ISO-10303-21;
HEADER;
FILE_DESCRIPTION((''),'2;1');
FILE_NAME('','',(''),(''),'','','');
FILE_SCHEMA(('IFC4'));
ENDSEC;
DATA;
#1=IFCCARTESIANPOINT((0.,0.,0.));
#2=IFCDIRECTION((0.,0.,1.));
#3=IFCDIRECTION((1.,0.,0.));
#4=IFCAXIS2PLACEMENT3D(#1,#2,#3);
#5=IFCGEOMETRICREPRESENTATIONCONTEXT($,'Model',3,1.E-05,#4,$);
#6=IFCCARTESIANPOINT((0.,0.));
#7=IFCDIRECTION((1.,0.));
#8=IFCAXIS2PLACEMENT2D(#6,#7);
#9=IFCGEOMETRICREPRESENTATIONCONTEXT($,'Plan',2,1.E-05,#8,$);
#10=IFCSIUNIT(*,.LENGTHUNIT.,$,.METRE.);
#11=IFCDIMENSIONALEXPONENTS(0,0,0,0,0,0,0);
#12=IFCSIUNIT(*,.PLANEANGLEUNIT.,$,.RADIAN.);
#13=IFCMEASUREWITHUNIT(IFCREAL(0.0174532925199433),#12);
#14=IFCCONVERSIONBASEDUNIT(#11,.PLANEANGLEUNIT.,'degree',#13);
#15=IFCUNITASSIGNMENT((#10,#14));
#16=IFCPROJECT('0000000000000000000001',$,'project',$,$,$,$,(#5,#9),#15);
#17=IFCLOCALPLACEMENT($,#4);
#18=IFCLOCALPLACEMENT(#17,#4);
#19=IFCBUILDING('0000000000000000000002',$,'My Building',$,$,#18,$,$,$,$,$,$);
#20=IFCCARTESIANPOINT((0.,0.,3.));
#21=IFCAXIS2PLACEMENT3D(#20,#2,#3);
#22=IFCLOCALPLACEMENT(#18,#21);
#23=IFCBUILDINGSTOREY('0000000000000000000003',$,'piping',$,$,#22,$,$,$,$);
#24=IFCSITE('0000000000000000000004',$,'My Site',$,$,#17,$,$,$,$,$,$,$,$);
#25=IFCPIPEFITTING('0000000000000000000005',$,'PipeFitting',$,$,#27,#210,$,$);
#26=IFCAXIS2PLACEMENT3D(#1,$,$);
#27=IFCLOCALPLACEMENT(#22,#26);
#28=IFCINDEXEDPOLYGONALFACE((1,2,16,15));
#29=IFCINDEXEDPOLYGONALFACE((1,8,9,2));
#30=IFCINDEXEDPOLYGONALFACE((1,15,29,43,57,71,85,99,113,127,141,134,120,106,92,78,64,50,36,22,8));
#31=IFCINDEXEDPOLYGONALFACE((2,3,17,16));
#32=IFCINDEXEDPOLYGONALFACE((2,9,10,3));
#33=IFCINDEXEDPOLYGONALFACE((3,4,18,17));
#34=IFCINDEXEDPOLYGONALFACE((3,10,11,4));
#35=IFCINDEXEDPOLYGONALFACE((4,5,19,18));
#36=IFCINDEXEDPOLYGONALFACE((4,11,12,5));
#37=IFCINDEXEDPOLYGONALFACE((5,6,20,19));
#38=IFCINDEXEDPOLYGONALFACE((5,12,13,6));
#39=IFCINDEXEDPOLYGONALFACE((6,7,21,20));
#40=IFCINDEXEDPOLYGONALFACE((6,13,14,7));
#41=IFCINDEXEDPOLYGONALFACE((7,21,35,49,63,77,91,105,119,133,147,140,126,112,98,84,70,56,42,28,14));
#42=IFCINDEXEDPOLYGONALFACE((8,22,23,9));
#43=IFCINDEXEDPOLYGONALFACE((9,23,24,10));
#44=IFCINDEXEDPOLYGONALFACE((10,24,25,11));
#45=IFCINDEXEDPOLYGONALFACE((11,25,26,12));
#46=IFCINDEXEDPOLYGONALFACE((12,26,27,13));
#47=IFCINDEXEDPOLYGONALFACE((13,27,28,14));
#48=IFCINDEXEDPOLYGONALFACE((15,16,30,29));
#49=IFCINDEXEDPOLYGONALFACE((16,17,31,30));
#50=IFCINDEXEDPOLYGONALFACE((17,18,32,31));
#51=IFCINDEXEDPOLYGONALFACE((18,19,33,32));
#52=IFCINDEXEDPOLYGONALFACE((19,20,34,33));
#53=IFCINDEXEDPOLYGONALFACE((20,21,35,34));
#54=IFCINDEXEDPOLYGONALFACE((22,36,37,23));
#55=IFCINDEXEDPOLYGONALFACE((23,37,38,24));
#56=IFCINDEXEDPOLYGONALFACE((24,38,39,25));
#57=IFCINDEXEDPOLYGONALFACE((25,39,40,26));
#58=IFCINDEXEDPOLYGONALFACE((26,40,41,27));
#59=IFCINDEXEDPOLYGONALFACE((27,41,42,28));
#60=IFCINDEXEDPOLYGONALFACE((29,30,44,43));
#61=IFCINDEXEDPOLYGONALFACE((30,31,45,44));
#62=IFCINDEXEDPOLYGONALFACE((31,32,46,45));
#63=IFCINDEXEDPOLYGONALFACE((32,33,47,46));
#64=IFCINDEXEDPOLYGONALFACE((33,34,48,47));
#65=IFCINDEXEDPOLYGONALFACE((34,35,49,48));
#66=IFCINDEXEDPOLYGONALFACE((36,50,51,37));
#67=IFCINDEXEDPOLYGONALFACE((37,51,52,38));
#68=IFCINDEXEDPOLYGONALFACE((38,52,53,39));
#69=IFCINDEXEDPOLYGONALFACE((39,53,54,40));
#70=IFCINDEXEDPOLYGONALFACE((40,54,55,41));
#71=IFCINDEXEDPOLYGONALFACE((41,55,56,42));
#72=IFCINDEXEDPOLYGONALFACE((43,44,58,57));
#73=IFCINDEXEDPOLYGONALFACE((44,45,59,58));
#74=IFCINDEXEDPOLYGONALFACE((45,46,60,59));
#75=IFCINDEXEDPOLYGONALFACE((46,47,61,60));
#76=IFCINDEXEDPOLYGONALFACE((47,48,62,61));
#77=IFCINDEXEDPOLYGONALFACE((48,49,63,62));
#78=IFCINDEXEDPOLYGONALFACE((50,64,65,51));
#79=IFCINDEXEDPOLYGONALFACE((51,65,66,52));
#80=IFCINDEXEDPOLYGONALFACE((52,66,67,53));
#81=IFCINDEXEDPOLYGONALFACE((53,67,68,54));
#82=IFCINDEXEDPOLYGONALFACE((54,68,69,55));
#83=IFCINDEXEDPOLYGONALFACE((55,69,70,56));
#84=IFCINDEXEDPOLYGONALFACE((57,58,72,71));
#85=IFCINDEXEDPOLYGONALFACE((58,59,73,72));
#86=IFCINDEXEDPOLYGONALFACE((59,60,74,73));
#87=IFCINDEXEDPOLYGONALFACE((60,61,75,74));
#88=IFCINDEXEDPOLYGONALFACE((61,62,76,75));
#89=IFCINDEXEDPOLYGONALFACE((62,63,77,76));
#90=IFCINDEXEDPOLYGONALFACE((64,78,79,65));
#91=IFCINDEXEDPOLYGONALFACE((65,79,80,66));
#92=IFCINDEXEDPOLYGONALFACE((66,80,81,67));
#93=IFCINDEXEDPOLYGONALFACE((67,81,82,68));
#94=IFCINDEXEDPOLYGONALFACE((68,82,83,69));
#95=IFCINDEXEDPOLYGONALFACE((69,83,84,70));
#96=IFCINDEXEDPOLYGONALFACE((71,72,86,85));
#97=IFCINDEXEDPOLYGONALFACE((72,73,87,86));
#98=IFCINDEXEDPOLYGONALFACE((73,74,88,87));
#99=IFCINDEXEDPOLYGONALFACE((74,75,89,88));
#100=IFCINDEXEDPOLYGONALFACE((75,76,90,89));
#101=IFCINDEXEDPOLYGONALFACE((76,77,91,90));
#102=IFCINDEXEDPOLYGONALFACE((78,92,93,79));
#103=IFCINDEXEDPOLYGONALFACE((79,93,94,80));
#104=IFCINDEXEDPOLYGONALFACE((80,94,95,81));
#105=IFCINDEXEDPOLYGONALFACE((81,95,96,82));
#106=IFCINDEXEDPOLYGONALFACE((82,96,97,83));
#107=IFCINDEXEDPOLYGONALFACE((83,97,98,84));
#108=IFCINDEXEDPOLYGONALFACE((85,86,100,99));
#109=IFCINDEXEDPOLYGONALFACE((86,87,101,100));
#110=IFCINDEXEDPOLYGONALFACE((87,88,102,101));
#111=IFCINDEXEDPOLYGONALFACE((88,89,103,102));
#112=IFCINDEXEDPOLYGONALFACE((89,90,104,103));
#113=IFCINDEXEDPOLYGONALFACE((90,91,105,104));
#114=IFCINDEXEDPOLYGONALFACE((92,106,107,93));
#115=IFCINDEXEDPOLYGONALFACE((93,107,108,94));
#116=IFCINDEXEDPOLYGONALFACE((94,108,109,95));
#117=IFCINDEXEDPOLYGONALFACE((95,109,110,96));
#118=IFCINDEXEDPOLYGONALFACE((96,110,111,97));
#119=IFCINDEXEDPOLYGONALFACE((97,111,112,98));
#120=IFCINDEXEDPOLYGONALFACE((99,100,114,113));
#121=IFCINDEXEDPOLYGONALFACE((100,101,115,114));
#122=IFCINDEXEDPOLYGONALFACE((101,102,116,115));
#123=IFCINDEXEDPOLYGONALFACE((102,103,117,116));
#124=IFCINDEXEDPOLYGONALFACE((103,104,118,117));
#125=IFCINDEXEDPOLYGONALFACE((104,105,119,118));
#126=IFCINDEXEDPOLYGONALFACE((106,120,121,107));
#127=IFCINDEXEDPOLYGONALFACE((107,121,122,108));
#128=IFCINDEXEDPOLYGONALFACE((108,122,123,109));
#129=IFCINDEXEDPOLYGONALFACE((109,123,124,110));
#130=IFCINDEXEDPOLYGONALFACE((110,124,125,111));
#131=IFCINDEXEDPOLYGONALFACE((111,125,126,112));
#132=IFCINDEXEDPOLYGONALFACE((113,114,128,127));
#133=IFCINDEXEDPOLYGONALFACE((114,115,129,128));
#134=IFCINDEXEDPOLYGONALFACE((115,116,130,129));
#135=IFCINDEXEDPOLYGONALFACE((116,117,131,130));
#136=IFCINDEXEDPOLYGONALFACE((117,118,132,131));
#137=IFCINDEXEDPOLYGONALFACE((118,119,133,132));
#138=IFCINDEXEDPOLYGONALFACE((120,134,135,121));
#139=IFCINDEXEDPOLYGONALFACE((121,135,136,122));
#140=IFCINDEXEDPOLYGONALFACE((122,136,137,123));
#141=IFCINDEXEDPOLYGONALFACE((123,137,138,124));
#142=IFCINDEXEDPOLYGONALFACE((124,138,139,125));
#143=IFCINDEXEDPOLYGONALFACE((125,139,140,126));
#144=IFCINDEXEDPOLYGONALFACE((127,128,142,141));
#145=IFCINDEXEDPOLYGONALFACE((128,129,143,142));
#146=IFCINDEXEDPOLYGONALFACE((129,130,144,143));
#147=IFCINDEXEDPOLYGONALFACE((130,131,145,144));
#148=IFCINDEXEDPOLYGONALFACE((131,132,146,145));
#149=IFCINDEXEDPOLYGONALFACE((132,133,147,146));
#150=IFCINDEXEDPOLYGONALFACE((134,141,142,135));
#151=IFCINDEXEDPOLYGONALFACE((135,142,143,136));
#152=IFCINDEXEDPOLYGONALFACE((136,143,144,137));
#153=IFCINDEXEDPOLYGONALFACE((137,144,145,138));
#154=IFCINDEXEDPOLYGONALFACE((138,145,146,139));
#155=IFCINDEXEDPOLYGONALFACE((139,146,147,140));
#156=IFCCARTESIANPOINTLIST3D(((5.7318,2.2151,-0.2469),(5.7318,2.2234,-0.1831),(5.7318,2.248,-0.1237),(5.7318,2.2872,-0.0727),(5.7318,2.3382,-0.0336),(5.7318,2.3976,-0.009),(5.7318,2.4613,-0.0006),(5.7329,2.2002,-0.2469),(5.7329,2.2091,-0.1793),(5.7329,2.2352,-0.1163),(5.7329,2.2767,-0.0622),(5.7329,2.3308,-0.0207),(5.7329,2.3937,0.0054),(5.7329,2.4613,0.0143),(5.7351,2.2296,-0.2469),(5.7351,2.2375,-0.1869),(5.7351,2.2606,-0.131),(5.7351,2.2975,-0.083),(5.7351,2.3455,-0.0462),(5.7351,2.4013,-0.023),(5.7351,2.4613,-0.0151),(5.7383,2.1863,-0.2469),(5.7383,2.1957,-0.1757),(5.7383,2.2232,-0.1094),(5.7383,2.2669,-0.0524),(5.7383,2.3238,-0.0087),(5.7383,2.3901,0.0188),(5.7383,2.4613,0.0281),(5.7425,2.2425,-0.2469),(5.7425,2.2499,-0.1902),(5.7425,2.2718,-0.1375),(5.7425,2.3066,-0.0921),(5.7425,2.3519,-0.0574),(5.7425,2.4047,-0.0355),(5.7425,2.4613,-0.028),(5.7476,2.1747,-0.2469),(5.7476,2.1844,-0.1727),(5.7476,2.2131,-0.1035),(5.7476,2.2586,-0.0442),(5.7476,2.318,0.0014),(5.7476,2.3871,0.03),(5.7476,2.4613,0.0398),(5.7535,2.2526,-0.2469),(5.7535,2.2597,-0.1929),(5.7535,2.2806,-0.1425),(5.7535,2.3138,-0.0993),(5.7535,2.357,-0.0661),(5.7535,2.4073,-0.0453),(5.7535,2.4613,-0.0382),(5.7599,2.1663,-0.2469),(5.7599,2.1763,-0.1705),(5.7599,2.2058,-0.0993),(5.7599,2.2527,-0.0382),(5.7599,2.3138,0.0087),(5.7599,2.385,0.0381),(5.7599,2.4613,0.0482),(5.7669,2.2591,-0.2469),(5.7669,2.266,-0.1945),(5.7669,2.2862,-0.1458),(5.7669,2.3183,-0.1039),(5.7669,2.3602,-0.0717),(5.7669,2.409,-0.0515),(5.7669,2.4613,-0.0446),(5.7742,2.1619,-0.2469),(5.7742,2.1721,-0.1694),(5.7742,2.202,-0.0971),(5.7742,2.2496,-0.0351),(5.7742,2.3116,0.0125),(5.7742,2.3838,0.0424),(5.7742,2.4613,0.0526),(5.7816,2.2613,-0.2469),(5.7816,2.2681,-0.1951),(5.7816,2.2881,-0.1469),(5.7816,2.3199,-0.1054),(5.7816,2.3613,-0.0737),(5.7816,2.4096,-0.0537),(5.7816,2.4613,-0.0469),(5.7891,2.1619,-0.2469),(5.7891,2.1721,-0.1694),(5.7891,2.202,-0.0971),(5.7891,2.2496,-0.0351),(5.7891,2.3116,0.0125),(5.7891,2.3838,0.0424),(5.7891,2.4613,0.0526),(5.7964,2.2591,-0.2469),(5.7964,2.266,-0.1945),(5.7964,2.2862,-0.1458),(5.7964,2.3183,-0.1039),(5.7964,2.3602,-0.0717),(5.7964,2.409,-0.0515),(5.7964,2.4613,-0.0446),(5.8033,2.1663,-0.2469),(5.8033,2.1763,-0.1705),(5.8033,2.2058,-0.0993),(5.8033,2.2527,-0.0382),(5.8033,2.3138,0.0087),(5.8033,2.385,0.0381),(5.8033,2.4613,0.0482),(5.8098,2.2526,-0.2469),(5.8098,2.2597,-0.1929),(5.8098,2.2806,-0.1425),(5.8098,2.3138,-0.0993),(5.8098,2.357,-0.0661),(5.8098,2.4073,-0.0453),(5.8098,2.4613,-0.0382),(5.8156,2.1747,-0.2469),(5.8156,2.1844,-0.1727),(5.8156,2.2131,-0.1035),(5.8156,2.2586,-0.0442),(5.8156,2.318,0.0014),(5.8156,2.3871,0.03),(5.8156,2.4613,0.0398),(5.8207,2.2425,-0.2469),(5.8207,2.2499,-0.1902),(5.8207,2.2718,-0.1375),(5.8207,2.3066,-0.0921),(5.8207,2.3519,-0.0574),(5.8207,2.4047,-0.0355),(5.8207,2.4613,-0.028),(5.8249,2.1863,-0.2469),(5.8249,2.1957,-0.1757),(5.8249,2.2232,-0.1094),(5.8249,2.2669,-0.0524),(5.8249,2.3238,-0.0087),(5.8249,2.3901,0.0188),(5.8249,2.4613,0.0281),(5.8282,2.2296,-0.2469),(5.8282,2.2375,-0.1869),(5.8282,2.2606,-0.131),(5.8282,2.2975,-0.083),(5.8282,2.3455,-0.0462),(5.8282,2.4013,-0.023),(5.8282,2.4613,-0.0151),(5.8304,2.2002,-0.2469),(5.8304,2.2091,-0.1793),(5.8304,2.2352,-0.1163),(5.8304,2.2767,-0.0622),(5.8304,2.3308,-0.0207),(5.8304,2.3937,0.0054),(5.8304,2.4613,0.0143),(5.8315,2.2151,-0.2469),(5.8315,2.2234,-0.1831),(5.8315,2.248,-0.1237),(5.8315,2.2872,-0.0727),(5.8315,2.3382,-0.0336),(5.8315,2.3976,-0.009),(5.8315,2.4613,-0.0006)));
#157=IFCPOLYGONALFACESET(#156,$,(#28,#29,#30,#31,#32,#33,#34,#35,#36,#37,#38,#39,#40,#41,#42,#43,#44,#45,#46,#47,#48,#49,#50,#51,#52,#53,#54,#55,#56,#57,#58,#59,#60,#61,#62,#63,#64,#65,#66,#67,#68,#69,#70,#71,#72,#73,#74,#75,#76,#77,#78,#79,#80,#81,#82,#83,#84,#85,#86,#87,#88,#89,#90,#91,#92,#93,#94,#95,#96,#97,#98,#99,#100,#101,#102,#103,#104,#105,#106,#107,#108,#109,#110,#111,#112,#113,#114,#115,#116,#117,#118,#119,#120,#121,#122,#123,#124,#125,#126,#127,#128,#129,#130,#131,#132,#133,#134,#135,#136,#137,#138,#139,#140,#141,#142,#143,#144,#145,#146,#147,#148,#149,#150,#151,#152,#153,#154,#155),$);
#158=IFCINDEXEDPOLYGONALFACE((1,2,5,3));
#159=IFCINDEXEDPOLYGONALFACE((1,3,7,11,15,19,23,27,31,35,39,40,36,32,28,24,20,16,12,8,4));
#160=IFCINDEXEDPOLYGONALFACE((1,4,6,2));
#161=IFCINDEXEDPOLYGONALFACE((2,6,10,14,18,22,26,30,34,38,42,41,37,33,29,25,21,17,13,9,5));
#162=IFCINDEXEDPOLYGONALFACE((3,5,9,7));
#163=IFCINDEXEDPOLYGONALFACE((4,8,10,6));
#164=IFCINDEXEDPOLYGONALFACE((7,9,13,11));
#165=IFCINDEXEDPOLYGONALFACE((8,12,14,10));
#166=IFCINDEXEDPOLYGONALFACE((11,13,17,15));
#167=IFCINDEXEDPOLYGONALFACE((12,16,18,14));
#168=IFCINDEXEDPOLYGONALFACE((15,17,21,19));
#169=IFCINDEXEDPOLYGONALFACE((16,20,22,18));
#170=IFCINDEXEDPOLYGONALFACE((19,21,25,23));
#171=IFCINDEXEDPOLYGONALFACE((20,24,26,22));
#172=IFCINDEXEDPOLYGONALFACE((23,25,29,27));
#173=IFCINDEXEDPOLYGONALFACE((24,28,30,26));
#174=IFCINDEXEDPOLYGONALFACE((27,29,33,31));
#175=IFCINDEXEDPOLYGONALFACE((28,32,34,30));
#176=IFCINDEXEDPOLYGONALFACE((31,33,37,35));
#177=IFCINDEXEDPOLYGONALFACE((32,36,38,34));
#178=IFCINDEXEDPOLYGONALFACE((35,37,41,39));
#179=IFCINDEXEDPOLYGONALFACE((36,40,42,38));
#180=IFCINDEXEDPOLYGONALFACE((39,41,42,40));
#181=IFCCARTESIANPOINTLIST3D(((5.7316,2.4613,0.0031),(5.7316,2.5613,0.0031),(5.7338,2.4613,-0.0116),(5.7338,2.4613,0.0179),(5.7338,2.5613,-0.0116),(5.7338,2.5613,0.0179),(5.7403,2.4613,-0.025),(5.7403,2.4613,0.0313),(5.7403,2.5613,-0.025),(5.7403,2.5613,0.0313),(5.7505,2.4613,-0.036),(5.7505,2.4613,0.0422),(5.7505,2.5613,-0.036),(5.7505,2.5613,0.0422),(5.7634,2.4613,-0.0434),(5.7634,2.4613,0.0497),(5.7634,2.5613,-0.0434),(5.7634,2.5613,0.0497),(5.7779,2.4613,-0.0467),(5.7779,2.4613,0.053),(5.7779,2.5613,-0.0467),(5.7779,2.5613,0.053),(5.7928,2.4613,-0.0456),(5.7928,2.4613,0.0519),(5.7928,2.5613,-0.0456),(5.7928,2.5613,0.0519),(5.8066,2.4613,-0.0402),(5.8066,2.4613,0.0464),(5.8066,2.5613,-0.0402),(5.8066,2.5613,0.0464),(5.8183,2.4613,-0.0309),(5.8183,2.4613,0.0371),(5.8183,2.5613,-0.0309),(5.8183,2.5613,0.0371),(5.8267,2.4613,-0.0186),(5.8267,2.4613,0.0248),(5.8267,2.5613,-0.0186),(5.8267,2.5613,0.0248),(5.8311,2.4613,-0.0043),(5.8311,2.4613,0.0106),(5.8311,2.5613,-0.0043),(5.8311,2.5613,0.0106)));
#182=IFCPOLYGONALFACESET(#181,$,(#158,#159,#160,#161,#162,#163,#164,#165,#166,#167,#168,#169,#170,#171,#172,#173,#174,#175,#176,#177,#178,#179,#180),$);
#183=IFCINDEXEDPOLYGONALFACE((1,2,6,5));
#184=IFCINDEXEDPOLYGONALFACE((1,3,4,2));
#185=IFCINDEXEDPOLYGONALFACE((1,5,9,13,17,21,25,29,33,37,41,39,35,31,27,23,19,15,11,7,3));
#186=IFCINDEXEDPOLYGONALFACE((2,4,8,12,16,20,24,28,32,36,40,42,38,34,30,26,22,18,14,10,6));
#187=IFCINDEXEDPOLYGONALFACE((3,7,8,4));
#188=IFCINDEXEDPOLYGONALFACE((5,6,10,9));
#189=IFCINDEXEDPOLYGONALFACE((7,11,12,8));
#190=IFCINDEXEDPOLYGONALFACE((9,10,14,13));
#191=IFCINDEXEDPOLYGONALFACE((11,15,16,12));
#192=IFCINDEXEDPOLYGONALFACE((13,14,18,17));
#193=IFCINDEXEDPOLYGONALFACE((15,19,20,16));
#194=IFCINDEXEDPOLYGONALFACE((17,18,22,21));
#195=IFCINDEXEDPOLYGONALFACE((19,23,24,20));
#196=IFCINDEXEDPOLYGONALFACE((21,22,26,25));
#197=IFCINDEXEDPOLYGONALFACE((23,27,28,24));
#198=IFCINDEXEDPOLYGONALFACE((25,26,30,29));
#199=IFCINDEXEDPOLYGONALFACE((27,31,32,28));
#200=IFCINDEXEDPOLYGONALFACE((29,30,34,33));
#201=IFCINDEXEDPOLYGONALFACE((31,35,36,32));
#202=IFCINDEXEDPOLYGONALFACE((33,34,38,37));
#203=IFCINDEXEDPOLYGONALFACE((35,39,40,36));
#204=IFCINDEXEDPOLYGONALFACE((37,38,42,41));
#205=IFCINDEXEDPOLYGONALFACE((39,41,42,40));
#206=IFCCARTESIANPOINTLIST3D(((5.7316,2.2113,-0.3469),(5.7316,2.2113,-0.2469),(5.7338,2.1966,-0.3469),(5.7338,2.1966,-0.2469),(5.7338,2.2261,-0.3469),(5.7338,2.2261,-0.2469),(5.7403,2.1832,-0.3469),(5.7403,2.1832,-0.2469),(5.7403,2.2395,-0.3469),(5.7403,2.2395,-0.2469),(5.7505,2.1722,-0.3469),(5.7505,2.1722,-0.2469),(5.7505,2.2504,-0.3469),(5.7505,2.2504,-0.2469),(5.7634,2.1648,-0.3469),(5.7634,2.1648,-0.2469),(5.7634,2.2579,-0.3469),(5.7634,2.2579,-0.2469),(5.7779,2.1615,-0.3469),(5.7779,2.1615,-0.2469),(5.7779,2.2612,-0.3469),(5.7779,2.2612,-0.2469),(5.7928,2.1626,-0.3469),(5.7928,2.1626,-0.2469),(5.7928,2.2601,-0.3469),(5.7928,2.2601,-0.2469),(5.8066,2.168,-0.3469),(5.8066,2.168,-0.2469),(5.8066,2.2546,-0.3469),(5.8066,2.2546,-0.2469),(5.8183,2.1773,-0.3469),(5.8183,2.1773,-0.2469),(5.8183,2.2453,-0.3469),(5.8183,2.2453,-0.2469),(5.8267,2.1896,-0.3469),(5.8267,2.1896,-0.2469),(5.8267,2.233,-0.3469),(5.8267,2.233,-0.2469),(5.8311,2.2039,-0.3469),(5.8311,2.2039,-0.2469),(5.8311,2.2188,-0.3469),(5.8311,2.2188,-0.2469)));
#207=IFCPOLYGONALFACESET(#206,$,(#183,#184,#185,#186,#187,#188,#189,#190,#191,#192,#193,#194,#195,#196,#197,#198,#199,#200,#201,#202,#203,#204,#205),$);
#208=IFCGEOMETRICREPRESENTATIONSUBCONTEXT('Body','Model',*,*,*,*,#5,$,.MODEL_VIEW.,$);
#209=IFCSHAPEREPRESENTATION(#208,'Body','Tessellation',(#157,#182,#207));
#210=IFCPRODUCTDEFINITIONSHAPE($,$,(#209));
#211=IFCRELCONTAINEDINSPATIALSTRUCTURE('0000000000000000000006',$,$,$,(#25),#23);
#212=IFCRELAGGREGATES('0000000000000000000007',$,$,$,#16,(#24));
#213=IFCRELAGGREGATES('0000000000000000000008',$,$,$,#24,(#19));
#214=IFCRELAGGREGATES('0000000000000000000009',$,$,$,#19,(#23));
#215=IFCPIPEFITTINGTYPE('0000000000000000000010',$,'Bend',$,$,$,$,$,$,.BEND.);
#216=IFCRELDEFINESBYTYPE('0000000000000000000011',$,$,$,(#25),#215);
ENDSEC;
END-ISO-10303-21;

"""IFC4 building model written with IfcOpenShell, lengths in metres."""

from ifc_helpers import new_model, entity, si_unit, converted_unit, frame, origin_with_axes, origin_2d_with_axis, place, context, subcontext, project, spatial, circle, extrude, source, transform, mapped, type_object, type_shapes, element, save


model = new_model("IFC4")

# Units and contexts
model_context = context("Model", 3, precision=1e-05, world=origin_with_axes())
plan_context = context("Plan", 2, precision=1e-05, world=origin_2d_with_axis())
body_context = subcontext(model_context, "Body", "Model", "MODEL_VIEW")
ifc_project = project(units=[si_unit("LENGTHUNIT", "METRE"), converted_unit("PLANEANGLEUNIT", "degree", entity("IfcReal", 0.0174532925199433), si_unit("PLANEANGLEUNIT", "RADIAN"), dimensions=[0, 0, 0, 0, 0, 0, 0])], contexts=[model_context, plan_context])

# Site, building, storey
site_placement = place(None, origin_with_axes())
site = spatial("IfcSite", under=ifc_project, at=site_placement, Name="My Site")
building_placement = place(site_placement, origin_with_axes())
building = spatial("IfcBuilding", under=site, at=building_placement, Name="My Building")
storey_placement = place(building_placement, frame((0.0, 0.0, 3.0), z_axis=(0.0, 0.0, 1.0), x_axis=(1.0, 0.0, 0.0)))
storey = spatial("IfcBuildingStorey", under=building, at=storey_placement, Name="piping")

# Pipe fitting
pipe_fitting_type = type_object("IfcPipeFittingType", Name="Bend", PredefinedType="BEND")
shared_shape = source(origin_with_axes(), body_context, "Body", "SolidModel", [
    entity("IfcSweptDiskSolid", entity("IfcIndexedPolyCurve", entity("IfcCartesianPointList3D", [[0.0, 0.0, -0.1], [0.0, -0.0732, -0.2768], [0.0, -0.25, -0.35]]), [entity("IfcArcIndex", [1, 2, 3])]), 0.05),
    extrude(circle(Radius=0.05), origin_with_axes(), (0.0, 0.0, -1.0), 0.1),
    extrude(circle(Radius=0.05), frame((0.0, -0.25, -0.35), z_axis=(0.0, -1.0, 0.0), x_axis=(1.0, 0.0, 0.0)), (0.0, 0.0, 1.0), 0.1),
])
type_shapes(pipe_fitting_type, [shared_shape])
for number, where, z_axis, x_axis, name in (
    (1, (5.7816, 2.5613, 0.0031), (0.0, 1.0, 0.0), (-1.0, 0.0, 0.0), "PipeFitting"),
):
    element("IfcPipeFitting", number, at=place(storey_placement, frame(where, z_axis=z_axis, x_axis=x_axis)), inside=storey, type_object=pipe_fitting_type, Name=name, context=body_context, shape_type="MappedRepresentation", body=[
        mapped(shared_shape, transform((0.0, 0.0, 0.0), x_axis=(1.0, 0.0, 0.0), y_axis=(0.0, 1.0, 0.0), z_axis=(0.0, 0.0, 1.0), scale=1.0)),
    ])

save(model, "model.ifc")
